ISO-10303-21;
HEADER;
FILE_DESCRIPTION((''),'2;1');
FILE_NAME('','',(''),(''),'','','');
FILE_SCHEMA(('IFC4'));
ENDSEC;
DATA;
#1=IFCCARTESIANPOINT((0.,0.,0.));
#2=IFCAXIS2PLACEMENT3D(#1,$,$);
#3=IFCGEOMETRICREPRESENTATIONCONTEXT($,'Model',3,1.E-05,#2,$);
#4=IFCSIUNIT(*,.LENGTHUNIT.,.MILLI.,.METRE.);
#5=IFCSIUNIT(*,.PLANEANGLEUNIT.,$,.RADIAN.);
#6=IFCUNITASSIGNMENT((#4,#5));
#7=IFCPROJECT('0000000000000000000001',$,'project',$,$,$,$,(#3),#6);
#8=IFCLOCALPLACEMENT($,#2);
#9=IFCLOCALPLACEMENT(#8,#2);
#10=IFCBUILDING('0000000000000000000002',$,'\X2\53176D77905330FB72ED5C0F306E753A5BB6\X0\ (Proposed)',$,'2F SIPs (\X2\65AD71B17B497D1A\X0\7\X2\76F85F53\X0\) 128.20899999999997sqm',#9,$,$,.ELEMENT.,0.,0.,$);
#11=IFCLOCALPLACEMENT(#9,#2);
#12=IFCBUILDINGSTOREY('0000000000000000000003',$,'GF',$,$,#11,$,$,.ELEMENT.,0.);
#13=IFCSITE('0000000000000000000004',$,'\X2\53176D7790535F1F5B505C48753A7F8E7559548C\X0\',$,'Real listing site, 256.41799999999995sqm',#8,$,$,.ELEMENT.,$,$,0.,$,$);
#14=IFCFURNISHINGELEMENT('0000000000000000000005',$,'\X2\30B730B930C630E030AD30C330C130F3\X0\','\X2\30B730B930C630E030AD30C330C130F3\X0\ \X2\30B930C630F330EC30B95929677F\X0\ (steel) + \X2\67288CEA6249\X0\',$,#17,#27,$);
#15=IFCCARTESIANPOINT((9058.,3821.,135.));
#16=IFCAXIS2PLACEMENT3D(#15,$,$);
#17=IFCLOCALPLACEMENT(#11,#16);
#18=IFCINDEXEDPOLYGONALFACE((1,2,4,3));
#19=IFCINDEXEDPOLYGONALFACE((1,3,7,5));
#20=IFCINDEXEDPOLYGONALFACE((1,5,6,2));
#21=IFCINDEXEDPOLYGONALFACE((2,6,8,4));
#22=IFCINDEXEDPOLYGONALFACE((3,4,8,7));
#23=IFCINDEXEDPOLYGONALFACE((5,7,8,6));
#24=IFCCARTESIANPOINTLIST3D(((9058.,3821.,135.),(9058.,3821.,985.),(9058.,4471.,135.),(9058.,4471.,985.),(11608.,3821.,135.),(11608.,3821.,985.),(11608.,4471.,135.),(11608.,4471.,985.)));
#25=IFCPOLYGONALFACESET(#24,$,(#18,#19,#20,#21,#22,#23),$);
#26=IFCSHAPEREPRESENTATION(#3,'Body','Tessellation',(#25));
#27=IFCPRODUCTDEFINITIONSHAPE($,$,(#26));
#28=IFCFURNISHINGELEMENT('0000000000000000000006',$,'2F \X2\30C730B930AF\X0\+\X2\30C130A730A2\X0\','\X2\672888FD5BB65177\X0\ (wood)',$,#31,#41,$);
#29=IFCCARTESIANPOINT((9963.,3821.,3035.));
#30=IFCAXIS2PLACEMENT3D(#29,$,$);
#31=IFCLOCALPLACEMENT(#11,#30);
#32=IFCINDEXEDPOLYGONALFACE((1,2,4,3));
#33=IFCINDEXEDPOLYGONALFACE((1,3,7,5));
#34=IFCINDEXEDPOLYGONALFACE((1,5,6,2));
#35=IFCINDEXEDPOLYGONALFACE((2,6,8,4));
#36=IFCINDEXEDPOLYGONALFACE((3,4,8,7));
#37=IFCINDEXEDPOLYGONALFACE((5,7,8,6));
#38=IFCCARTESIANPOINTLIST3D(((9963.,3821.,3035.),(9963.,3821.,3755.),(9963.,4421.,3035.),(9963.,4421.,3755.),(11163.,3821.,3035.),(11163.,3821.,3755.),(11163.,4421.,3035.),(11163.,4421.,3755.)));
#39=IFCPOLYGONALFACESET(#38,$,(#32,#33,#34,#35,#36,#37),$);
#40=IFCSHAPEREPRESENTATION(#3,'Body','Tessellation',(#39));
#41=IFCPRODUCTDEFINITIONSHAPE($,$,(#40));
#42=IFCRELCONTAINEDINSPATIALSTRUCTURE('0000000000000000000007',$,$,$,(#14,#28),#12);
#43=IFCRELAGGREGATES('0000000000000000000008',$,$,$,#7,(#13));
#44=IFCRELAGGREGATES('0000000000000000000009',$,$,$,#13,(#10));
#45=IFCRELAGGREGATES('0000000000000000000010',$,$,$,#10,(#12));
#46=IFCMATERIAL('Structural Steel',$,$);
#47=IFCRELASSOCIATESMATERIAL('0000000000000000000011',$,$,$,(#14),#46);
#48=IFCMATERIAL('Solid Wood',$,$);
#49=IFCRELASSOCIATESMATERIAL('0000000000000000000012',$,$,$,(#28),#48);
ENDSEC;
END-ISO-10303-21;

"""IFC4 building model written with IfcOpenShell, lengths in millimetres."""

from ifc_helpers import new_model, si_unit, frame, frame_2d, origin, place, context, project, spatial, rectangle, extrude, material, element, save


model = new_model("IFC4")

# Units and contexts
model_context = context("Model", 3, precision=1e-05, world=origin())
ifc_project = project(units=[si_unit("LENGTHUNIT", "METRE", prefix="MILLI"), si_unit("PLANEANGLEUNIT", "RADIAN")], contexts=[model_context])

# Site, building, storey
site_placement = place(None, origin())
site = spatial("IfcSite", under=ifc_project, at=site_placement, Name="北海道弟子屈町美留和", ObjectType="Real listing site, 256.41799999999995sqm", CompositionType="ELEMENT", RefElevation=0.0)
building_placement = place(site_placement, origin())
building = spatial("IfcBuilding", under=site, at=building_placement, Name="北海道・狭小の町家 (Proposed)", ObjectType="2F SIPs (断熱等級7相当) 128.20899999999997sqm", CompositionType="ELEMENT", ElevationOfRefHeight=0.0, ElevationOfTerrain=0.0)
storey_placement = place(building_placement, origin())
storey = spatial("IfcBuildingStorey", under=building, at=storey_placement, Name="GF", CompositionType="ELEMENT", Elevation=0.0)

# Shared definitions
ifc_material_1 = material(Name="Solid Wood")

# Furnishing elements
ifc_material_2 = material(Name="Structural Steel")
furnishing_1_placement = place(storey_placement, frame((9058.0, 3821.0, 135.0)))
element("IfcFurnishingElement", 1, at=furnishing_1_placement, inside=storey, material=ifc_material_2, Name="システムキッチン", Description="システムキッチン ステンレス天板 (steel) + 木質扉", context=model_context, shape_type="SweptSolid", body=[
    extrude(rectangle(XDim=2550.0, YDim=650.0, at=frame_2d((1275.0, 325.0))), frame((9058.0, 3821.0, 135.0)), (0.0, 0.0, 1.0), 850.0),
])
furnishing_2_placement = place(storey_placement, frame((9963.0, 3821.0, 3035.0)))
element("IfcFurnishingElement", 2, at=furnishing_2_placement, inside=storey, material=ifc_material_1, Name="2F デスク+チェア", Description="木製家具 (wood)", context=model_context, shape_type="SweptSolid", body=[
    extrude(rectangle(XDim=1200.0, YDim=600.0, at=frame_2d((600.0, 300.0))), frame((9963.0, 3821.0, 3035.0)), (0.0, 0.0, 1.0), 720.0),
])

save(model, "model.ifc")
